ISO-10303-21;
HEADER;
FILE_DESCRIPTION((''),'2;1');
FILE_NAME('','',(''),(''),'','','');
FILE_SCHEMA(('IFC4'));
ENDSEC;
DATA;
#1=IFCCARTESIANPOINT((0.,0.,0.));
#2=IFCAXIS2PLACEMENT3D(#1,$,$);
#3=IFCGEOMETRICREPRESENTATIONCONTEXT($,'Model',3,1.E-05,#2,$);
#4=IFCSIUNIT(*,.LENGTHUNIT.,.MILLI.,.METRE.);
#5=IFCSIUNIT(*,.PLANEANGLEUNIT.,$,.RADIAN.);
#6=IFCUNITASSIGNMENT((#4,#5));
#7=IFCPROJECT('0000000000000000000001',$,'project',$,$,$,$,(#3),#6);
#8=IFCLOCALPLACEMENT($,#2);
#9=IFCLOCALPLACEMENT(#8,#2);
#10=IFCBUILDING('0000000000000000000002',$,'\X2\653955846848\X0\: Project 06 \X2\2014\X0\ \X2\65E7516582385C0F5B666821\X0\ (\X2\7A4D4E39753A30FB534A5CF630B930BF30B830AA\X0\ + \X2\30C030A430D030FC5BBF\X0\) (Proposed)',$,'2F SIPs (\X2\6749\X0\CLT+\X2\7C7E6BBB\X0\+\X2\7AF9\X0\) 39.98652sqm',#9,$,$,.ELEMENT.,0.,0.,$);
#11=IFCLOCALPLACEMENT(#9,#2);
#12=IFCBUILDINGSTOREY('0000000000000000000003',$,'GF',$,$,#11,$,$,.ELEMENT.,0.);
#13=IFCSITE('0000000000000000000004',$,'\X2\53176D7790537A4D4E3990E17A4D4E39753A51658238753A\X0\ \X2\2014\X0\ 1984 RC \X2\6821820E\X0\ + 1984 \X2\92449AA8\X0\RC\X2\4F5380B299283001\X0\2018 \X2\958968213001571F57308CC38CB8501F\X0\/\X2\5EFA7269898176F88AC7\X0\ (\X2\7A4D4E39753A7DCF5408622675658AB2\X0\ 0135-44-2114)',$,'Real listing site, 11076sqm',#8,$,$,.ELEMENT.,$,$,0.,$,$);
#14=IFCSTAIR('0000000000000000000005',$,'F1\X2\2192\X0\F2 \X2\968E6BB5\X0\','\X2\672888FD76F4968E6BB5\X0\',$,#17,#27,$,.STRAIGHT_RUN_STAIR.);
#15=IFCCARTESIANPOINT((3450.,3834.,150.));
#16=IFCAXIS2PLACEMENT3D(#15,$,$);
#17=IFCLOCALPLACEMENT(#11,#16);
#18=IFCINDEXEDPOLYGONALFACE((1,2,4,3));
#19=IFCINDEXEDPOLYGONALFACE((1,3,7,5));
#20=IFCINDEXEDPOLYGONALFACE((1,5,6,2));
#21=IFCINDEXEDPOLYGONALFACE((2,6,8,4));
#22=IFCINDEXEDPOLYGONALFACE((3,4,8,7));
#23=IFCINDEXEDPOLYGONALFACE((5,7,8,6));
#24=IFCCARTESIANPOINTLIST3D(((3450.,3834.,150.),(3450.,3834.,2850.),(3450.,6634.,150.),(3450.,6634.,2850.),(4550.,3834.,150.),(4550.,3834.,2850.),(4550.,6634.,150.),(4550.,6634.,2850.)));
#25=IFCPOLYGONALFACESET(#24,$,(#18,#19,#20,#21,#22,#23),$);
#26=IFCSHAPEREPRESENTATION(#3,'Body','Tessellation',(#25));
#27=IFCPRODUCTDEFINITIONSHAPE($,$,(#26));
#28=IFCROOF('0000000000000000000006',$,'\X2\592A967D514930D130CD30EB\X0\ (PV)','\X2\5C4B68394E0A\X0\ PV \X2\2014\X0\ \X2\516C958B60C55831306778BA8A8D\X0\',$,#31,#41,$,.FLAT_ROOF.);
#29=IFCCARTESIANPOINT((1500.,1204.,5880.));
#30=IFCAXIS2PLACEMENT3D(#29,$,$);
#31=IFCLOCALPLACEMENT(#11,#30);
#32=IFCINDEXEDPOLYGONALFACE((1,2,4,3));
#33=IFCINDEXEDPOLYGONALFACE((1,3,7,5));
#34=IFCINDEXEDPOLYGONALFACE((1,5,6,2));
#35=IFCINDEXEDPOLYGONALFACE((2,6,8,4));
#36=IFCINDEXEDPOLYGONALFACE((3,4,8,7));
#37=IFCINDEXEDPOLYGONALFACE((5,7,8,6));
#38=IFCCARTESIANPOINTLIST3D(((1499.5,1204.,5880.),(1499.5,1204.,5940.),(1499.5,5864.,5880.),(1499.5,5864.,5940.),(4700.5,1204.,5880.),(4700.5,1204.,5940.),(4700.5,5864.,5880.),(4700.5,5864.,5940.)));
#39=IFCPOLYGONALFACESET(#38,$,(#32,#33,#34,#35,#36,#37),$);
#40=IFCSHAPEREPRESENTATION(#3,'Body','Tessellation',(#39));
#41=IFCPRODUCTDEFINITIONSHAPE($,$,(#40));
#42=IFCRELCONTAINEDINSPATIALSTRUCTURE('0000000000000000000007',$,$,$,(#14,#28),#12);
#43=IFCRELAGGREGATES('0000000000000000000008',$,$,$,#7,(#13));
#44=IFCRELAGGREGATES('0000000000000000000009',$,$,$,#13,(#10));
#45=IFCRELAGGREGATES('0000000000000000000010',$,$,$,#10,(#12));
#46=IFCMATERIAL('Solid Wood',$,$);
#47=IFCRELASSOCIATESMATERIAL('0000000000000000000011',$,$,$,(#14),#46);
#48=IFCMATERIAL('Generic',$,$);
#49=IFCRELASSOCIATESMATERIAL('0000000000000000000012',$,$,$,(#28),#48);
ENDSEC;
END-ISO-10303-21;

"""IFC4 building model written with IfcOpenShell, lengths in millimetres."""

from ifc_helpers import new_model, si_unit, frame, frame_2d, origin, place, context, project, spatial, rectangle, extrude, material, element, save


model = new_model("IFC4")

# Units and contexts
model_context = context("Model", 3, precision=1e-05, world=origin())
ifc_project = project(units=[si_unit("LENGTHUNIT", "METRE", prefix="MILLI"), si_unit("PLANEANGLEUNIT", "RADIAN")], contexts=[model_context])

# Site, building, storey
site_placement = place(None, origin())
site = spatial("IfcSite", under=ifc_project, at=site_placement, Name="北海道積丹郡積丹町入舸町 — 1984 RC 校舎 + 1984 鉄骨RC体育館、2018 閉校、土地賃貸借/建物要相談 (積丹町総合戦略課 0135-44-2114)", ObjectType="Real listing site, 11076sqm", CompositionType="ELEMENT", RefElevation=0.0)
building_placement = place(site_placement, origin())
building = spatial("IfcBuilding", under=site, at=building_placement, Name="改善案: Project 06 — 旧入舸小学校 (積丹町・半島スタジオ + ダイバー宿) (Proposed)", ObjectType="2F SIPs (杉CLT+籾殻+竹) 39.98652sqm", CompositionType="ELEMENT", ElevationOfRefHeight=0.0, ElevationOfTerrain=0.0)
storey_placement = place(building_placement, origin())
storey = spatial("IfcBuildingStorey", under=building, at=storey_placement, Name="GF", CompositionType="ELEMENT", Elevation=0.0)

# Shared definitions
ifc_material_1 = material(Name="Generic")

# Stair
ifc_material_2 = material(Name="Solid Wood")
stair_placement = place(storey_placement, frame((3450.0, 3834.0, 150.0)))
element("IfcStair", 1, at=stair_placement, inside=storey, material=ifc_material_2, Name="F1→F2 階段", Description="木製直階段", PredefinedType="STRAIGHT_RUN_STAIR", context=model_context, shape_type="SweptSolid", body=[
    extrude(rectangle(XDim=1100.0, YDim=2800.0, at=frame_2d((550.0, 1400.0))), frame((3450.0, 3834.0, 150.0)), (0.0, 0.0, 1.0), 2700.0),
])

# Roof
roof_placement = place(storey_placement, frame((1500.0, 1204.0, 5880.0)))
element("IfcRoof", 2, at=roof_placement, inside=storey, material=ifc_material_1, Name="太陽光パネル (PV)", Description="屋根上 PV — 公開情報で確認", PredefinedType="FLAT_ROOF", context=model_context, shape_type="SweptSolid", body=[
    extrude(rectangle(XDim=3201.0, YDim=4660.0, at=frame_2d((1600.0, 2330.0))), frame((1500.0, 1204.0, 5880.0)), (0.0, 0.0, 1.0), 60.0),
])

save(model, "model.ifc")
